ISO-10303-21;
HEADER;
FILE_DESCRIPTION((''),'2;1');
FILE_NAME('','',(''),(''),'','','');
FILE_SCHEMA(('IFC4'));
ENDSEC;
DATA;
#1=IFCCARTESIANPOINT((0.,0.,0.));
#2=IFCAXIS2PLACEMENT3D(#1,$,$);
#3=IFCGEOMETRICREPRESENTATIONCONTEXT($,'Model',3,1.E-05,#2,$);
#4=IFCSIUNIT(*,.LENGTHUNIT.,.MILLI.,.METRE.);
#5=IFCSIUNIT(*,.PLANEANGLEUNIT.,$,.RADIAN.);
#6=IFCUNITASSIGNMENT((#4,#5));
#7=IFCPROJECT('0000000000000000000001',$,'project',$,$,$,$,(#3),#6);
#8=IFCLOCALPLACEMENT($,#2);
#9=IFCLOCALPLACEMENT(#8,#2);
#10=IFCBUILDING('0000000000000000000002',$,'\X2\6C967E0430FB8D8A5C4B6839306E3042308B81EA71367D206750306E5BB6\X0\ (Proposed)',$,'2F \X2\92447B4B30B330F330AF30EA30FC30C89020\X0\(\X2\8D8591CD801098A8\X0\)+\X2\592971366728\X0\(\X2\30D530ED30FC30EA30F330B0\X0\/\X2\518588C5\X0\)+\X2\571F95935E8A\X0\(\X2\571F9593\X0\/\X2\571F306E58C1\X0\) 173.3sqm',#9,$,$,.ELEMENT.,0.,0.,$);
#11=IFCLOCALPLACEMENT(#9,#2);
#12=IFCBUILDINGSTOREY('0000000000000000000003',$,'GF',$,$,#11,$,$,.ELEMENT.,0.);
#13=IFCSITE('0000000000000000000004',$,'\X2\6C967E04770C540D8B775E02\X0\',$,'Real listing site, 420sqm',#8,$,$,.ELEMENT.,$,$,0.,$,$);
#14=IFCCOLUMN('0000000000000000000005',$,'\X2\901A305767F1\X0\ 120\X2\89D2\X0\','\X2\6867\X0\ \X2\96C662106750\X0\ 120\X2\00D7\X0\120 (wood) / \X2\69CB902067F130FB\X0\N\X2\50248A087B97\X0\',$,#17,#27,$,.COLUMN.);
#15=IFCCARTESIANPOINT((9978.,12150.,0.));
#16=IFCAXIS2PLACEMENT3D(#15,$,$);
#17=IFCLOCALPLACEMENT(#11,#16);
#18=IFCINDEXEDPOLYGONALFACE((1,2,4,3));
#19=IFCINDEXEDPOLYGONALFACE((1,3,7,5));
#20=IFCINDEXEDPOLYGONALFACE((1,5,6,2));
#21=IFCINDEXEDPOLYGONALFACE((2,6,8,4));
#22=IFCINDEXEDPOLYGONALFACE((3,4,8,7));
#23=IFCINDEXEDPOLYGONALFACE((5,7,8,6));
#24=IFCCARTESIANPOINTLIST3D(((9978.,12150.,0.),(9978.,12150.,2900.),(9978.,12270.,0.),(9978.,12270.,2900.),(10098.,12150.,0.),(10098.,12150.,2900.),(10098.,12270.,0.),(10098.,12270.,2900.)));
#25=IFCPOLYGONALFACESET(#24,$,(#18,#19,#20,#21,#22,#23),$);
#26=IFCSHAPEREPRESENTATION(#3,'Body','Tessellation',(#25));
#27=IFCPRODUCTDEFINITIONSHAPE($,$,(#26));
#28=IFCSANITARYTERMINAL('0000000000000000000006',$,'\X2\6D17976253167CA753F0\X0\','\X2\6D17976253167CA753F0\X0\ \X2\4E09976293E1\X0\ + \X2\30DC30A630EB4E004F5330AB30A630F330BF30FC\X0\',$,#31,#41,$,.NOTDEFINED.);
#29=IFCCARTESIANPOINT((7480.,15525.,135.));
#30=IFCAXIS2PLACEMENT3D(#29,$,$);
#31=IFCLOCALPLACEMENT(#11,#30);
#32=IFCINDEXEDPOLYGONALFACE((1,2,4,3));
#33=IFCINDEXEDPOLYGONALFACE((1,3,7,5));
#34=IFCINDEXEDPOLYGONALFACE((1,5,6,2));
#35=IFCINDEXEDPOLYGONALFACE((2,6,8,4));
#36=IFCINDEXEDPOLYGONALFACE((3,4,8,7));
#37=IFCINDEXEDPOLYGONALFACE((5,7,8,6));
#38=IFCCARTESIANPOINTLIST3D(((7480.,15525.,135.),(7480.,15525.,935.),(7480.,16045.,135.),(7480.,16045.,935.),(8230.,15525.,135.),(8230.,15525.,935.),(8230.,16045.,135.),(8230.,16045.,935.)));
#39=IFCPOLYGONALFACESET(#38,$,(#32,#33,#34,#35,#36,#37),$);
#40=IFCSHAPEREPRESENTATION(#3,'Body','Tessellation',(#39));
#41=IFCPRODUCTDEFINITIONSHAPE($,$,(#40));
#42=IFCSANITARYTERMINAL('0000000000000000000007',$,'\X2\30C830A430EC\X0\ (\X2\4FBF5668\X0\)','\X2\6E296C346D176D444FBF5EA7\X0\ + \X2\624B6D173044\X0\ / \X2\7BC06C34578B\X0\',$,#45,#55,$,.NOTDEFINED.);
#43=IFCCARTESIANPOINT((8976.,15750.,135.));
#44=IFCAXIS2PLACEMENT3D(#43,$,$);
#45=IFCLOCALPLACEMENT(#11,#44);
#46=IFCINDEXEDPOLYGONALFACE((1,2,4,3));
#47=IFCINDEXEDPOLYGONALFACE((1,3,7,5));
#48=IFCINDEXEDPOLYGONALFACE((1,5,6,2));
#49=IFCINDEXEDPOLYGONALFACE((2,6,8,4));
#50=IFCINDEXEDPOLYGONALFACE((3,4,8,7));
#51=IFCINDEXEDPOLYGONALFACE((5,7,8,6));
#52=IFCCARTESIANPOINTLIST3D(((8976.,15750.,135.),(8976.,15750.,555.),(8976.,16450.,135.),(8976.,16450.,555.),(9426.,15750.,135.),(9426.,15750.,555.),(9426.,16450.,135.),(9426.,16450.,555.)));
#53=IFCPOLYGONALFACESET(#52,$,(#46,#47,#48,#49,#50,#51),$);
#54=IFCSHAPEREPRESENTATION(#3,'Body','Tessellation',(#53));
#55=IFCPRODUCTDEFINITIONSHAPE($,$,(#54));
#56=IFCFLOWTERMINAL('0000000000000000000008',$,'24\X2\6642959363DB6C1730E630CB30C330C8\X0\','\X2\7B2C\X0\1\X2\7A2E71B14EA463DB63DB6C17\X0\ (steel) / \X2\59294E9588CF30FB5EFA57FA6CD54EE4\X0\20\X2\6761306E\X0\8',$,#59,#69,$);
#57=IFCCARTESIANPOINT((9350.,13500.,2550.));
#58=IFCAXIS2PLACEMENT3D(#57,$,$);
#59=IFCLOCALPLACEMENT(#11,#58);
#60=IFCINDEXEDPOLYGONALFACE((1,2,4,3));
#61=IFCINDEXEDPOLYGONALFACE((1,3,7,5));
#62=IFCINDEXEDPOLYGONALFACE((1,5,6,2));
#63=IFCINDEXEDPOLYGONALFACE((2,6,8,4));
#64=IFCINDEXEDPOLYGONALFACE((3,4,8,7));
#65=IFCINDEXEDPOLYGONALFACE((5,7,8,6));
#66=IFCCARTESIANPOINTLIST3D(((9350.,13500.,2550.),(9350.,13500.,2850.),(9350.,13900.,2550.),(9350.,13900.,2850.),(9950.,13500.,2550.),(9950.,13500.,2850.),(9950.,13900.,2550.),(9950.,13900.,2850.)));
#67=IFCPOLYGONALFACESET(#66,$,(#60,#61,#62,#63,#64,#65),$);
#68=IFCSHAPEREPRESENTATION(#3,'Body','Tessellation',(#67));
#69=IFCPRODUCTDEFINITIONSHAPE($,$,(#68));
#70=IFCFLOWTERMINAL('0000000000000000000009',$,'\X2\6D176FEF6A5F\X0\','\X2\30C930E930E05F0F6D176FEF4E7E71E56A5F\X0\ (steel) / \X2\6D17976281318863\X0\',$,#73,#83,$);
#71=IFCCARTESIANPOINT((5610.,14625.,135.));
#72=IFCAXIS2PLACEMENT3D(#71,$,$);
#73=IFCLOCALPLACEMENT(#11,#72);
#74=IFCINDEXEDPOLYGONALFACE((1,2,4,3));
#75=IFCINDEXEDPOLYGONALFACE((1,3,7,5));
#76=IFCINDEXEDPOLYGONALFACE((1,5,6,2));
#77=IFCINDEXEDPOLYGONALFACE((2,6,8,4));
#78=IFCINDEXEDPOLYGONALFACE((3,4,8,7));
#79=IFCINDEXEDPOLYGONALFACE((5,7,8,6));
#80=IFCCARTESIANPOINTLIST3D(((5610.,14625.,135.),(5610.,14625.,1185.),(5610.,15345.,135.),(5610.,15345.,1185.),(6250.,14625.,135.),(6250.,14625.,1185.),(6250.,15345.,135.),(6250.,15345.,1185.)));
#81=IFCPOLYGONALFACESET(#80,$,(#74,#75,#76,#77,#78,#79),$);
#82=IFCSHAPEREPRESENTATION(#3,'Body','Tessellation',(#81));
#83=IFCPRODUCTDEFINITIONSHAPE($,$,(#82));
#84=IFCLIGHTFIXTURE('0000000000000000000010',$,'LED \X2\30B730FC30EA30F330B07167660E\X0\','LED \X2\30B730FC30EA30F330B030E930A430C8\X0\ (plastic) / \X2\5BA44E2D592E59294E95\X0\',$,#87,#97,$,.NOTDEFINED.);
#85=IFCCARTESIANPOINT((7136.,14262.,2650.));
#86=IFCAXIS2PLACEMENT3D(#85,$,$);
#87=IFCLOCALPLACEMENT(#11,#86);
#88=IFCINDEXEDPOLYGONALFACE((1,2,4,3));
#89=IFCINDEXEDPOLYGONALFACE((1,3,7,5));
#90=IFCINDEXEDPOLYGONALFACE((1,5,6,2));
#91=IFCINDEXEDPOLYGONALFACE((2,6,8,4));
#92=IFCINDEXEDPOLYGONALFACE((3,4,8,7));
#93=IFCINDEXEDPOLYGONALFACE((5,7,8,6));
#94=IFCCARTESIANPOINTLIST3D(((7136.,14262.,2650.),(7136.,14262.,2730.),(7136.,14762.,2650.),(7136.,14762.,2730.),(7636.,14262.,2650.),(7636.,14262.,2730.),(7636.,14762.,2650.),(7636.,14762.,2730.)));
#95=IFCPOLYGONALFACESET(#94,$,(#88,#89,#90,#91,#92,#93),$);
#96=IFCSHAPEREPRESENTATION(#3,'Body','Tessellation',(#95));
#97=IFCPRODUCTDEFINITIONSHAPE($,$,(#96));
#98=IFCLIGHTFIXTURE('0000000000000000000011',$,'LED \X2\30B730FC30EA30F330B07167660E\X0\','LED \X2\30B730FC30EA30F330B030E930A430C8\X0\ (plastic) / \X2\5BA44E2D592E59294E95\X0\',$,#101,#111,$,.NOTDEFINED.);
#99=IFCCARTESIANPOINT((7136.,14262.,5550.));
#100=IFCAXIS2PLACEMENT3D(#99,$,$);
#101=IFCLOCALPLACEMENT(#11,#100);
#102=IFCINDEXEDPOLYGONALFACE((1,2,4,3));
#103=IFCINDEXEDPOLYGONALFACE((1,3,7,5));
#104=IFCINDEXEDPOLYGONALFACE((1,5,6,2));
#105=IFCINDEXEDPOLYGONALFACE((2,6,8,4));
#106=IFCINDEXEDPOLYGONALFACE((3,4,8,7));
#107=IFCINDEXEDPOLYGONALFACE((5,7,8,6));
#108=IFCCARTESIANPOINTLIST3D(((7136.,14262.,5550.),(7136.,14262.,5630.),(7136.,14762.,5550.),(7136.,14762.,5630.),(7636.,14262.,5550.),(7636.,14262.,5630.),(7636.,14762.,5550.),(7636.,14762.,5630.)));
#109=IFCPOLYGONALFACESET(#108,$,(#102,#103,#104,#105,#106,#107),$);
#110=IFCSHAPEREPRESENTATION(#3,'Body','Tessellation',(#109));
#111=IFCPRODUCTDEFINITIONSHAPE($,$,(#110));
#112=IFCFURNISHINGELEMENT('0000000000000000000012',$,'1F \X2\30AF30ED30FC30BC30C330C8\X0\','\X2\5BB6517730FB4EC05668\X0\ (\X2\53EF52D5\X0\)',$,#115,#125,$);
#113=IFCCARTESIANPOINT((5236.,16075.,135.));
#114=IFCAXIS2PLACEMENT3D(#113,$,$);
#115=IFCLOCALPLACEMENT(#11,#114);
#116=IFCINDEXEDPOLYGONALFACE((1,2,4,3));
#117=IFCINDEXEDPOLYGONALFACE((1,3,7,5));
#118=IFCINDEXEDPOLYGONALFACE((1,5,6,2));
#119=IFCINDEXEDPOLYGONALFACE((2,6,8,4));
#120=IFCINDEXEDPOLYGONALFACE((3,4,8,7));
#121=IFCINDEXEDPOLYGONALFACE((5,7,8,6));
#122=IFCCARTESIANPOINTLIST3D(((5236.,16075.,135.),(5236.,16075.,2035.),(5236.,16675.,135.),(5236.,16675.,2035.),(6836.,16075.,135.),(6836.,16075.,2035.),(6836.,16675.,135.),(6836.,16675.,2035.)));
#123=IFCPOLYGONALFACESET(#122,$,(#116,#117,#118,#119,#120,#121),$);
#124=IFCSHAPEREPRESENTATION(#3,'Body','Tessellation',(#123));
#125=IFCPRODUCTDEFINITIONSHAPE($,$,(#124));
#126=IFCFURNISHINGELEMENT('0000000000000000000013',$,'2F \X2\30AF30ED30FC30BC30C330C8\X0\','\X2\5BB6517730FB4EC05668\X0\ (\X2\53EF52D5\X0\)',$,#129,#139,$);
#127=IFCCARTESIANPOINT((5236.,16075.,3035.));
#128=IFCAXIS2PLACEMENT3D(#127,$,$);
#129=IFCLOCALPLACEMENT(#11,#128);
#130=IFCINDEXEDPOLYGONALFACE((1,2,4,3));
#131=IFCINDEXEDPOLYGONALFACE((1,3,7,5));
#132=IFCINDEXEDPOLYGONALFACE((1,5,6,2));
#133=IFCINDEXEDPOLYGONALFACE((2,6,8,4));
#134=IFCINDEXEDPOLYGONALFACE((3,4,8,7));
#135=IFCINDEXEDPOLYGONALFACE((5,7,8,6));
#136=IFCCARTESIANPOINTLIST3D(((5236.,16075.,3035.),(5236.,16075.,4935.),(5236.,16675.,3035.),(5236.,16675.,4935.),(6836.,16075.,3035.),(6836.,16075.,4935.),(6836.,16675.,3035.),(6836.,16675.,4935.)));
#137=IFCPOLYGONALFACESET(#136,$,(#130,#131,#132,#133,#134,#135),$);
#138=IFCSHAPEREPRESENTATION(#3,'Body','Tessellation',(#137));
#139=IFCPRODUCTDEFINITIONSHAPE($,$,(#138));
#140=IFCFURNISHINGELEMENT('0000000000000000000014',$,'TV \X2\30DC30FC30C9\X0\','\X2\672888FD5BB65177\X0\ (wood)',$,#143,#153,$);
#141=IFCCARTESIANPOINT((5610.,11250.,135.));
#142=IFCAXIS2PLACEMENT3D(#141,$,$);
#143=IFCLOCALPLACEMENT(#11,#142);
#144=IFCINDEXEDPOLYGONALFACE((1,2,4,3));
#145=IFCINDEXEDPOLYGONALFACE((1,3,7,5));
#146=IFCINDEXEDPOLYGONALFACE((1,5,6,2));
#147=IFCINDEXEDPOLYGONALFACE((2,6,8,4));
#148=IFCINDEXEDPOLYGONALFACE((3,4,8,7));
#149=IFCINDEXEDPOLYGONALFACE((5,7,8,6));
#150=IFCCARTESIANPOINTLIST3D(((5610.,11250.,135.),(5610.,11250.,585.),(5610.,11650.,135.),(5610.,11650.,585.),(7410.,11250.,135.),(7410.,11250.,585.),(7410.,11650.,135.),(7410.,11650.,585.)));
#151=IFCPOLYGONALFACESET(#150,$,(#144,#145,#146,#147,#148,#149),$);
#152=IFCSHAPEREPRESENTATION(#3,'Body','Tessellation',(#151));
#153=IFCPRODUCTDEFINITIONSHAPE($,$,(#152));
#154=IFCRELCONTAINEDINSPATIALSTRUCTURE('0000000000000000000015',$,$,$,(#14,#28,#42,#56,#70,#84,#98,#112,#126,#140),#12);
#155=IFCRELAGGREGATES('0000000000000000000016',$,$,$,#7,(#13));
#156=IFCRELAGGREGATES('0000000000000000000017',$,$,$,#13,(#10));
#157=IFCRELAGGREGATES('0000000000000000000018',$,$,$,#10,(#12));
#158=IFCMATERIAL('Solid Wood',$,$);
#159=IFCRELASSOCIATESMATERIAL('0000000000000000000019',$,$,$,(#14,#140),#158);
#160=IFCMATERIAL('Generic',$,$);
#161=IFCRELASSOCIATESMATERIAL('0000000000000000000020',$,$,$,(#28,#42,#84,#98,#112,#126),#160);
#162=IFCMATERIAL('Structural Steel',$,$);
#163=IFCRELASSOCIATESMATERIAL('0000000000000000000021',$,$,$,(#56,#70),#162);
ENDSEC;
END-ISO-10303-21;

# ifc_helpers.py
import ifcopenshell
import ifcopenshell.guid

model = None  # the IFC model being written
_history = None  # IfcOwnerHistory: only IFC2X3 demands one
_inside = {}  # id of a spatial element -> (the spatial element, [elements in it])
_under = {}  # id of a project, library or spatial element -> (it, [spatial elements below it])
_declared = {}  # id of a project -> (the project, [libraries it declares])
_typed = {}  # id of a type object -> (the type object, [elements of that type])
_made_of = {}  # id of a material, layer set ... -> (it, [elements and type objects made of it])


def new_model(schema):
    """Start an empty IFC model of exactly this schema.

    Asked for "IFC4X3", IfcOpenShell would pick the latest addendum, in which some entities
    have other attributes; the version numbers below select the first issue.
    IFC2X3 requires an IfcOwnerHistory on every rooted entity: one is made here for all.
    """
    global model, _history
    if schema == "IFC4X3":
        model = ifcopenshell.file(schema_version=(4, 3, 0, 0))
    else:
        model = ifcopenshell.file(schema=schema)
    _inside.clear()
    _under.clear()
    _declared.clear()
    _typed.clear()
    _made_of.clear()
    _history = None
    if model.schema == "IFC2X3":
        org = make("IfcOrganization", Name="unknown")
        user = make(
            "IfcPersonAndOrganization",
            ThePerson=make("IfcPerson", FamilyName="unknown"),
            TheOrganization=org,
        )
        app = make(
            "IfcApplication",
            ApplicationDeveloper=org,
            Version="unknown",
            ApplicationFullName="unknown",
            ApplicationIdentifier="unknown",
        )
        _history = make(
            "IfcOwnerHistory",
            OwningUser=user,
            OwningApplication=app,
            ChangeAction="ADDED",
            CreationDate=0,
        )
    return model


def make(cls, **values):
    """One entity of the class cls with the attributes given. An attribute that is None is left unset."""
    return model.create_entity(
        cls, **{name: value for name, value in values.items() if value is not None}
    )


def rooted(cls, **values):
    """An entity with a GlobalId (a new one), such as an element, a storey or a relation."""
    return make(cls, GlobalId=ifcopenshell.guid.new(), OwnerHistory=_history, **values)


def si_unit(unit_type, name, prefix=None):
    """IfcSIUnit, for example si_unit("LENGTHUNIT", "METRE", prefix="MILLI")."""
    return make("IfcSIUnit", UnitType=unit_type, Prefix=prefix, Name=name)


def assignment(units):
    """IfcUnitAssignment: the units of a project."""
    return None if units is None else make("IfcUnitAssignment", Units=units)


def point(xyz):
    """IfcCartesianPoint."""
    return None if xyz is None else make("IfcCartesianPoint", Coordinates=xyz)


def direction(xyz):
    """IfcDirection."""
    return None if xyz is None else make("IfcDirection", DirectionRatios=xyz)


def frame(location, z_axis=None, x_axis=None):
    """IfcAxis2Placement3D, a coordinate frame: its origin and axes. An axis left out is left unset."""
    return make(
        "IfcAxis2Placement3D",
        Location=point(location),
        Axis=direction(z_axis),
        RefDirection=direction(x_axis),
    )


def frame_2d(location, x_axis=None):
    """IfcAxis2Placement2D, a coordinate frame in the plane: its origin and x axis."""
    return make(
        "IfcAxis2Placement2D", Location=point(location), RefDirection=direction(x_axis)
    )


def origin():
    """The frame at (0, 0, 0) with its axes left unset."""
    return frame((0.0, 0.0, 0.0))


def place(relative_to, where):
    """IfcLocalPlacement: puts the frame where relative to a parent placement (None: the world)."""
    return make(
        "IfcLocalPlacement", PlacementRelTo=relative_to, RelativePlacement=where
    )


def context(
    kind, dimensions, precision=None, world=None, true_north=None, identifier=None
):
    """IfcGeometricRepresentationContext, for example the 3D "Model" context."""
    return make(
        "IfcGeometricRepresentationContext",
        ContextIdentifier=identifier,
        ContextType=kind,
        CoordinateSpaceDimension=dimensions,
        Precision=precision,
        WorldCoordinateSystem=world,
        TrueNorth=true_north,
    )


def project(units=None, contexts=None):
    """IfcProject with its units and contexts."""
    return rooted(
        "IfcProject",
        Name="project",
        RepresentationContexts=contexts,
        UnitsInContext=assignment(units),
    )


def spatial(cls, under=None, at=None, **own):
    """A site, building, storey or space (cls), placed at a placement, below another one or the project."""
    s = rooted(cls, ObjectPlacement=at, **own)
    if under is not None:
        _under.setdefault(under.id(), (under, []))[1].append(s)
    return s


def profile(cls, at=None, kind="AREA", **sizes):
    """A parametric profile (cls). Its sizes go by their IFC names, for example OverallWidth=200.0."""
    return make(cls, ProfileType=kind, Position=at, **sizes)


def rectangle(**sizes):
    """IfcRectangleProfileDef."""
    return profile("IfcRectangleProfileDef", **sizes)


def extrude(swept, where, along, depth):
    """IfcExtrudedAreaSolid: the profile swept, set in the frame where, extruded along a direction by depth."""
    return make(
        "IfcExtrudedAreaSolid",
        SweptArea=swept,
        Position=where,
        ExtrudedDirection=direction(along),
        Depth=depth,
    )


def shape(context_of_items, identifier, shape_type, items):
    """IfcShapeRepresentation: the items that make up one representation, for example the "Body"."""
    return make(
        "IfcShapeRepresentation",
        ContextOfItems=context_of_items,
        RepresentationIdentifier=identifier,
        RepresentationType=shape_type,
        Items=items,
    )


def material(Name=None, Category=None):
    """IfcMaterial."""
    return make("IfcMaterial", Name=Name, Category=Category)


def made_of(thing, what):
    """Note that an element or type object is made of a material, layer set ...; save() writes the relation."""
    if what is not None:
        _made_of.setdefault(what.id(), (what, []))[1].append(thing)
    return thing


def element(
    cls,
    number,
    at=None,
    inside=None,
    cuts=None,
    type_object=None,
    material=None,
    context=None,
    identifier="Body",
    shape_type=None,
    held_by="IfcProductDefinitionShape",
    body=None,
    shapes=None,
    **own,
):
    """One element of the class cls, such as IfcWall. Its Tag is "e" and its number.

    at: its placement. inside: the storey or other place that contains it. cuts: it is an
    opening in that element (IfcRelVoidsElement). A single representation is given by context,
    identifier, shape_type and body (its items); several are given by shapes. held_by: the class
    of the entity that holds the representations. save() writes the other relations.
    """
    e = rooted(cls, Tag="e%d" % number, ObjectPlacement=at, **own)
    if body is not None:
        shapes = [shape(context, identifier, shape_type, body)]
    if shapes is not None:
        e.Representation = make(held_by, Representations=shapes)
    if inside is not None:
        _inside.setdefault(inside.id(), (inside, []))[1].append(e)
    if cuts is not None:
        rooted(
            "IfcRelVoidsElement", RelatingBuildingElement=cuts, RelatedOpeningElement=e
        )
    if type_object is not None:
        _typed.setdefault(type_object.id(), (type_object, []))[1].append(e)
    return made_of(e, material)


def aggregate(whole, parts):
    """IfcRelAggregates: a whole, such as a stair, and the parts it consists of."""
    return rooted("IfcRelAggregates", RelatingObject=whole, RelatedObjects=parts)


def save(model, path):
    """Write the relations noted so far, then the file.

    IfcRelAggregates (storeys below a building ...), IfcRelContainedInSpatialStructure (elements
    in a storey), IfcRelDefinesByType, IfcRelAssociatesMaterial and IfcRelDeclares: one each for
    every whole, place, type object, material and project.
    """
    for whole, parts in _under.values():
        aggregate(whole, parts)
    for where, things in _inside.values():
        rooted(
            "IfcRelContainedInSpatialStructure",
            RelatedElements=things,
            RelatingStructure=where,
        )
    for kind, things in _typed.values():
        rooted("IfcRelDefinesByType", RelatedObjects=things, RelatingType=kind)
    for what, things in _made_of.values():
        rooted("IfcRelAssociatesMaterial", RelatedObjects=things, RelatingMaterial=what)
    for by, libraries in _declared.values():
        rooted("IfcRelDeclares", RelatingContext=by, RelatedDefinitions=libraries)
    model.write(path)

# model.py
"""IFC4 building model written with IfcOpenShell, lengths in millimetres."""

from ifc_helpers import new_model, si_unit, frame, frame_2d, origin, place, context, project, spatial, rectangle, extrude, material, element, save


model = new_model("IFC4")

# Units and contexts
model_context = context("Model", 3, precision=1e-05, world=origin())
ifc_project = project(units=[si_unit("LENGTHUNIT", "METRE", prefix="MILLI"), si_unit("PLANEANGLEUNIT", "RADIAN")], contexts=[model_context])

# Site, building, storey
site_placement = place(None, origin())
site = spatial("IfcSite", under=ifc_project, at=site_placement, Name="沖縄県名護市", ObjectType="Real listing site, 420sqm", CompositionType="ELEMENT", RefElevation=0.0)
building_placement = place(site_placement, origin())
building = spatial("IfcBuilding", under=site, at=building_placement, Name="沖縄・越屋根のある自然素材の家 (Proposed)", ObjectType="2F 鉄筋コンクリート造(超重耐風)+天然木(フローリング/内装)+土間床(土間/土の壁) 173.3sqm", CompositionType="ELEMENT", ElevationOfRefHeight=0.0, ElevationOfTerrain=0.0)
storey_placement = place(building_placement, origin())
storey = spatial("IfcBuildingStorey", under=building, at=storey_placement, Name="GF", CompositionType="ELEMENT", Elevation=0.0)

# Column
ifc_material_1 = material(Name="Solid Wood")
column_1_placement = place(storey_placement, frame((9978.0, 12150.0, 0.0)))
element("IfcColumn", 1, at=column_1_placement, inside=storey, material=ifc_material_1, Name="通し柱 120角", Description="桧 集成材 120×120 (wood) / 構造柱・N値計算", PredefinedType="COLUMN", context=model_context, shape_type="SweptSolid", body=[
    extrude(rectangle(XDim=120.0, YDim=120.0, at=frame_2d((60.0, 60.0))), frame((9978.0, 12150.0, 0.0)), (0.0, 0.0, 1.0), 2900.0),
])

# Sanitary terminals
ifc_material_2 = material(Name="Generic")
sanitary_terminal_1_placement = place(storey_placement, frame((7480.0, 15525.0, 135.0)))
element("IfcSanitaryTerminal", 2, at=sanitary_terminal_1_placement, inside=storey, material=ifc_material_2, Name="洗面化粧台", Description="洗面化粧台 三面鏡 + ボウル一体カウンター", PredefinedType="NOTDEFINED", context=model_context, shape_type="SweptSolid", body=[
    extrude(rectangle(XDim=750.0, YDim=520.0, at=frame_2d((375.0, 260.0))), frame((7480.0, 15525.0, 135.0)), (0.0, 0.0, 1.0), 800.0),
])
sanitary_terminal_2_placement = place(storey_placement, frame((8976.0, 15750.0, 135.0)))
element("IfcSanitaryTerminal", 3, at=sanitary_terminal_2_placement, inside=storey, material=ifc_material_2, Name="トイレ (便器)", Description="温水洗浄便座 + 手洗い / 節水型", PredefinedType="NOTDEFINED", context=model_context, shape_type="SweptSolid", body=[
    extrude(rectangle(XDim=450.0, YDim=700.0, at=frame_2d((225.0, 350.0))), frame((8976.0, 15750.0, 135.0)), (0.0, 0.0, 1.0), 420.0),
])

# Flow terminals
ifc_material_3 = material(Name="Structural Steel")
flow_terminal_1_placement = place(storey_placement, frame((9350.0, 13500.0, 2550.0)))
element("IfcFlowTerminal", 4, at=flow_terminal_1_placement, inside=storey, material=ifc_material_3, Name="24時間換気ユニット", Description="第1種熱交換換気 (steel) / 天井裏・建基法令20条の8", context=model_context, shape_type="SweptSolid", body=[
    extrude(rectangle(XDim=600.0, YDim=400.0, at=frame_2d((300.0, 200.0))), frame((9350.0, 13500.0, 2550.0)), (0.0, 0.0, 1.0), 300.0),
])
flow_terminal_2_placement = place(storey_placement, frame((5610.0, 14625.0, 135.0)))
element("IfcFlowTerminal", 5, at=flow_terminal_2_placement, inside=storey, material=ifc_material_3, Name="洗濯機", Description="ドラム式洗濯乾燥機 (steel) / 洗面脱衣", context=model_context, shape_type="SweptSolid", body=[
    extrude(rectangle(XDim=640.0, YDim=720.0, at=frame_2d((320.0, 360.0))), frame((5610.0, 14625.0, 135.0)), (0.0, 0.0, 1.0), 1050.0),
])

# Light fixtures
light_fixture_1_placement = place(storey_placement, frame((7136.0, 14262.0, 2650.0)))
element("IfcLightFixture", 6, at=light_fixture_1_placement, inside=storey, material=ifc_material_2, Name="LED シーリング照明", Description="LED シーリングライト (plastic) / 室中央天井", PredefinedType="NOTDEFINED", context=model_context, shape_type="SweptSolid", body=[
    extrude(rectangle(XDim=500.0, YDim=500.0, at=frame_2d((250.0, 250.0))), frame((7136.0, 14262.0, 2650.0)), (0.0, 0.0, 1.0), 80.0),
])
light_fixture_2_placement = place(storey_placement, frame((7136.0, 14262.0, 5550.0)))
element("IfcLightFixture", 7, at=light_fixture_2_placement, inside=storey, material=ifc_material_2, Name="LED シーリング照明", Description="LED シーリングライト (plastic) / 室中央天井", PredefinedType="NOTDEFINED", context=model_context, shape_type="SweptSolid", body=[
    extrude(rectangle(XDim=500.0, YDim=500.0, at=frame_2d((250.0, 250.0))), frame((7136.0, 14262.0, 5550.0)), (0.0, 0.0, 1.0), 80.0),
])

# Furnishing elements
furnishing_1_placement = place(storey_placement, frame((5236.0, 16075.0, 135.0)))
element("IfcFurnishingElement", 8, at=furnishing_1_placement, inside=storey, material=ifc_material_2, Name="1F クローゼット", Description="家具・什器 (可動)", context=model_context, shape_type="SweptSolid", body=[
    extrude(rectangle(XDim=1600.0, YDim=600.0, at=frame_2d((800.0, 300.0))), frame((5236.0, 16075.0, 135.0)), (0.0, 0.0, 1.0), 1900.0),
])
furnishing_2_placement = place(storey_placement, frame((5236.0, 16075.0, 3035.0)))
element("IfcFurnishingElement", 9, at=furnishing_2_placement, inside=storey, material=ifc_material_2, Name="2F クローゼット", Description="家具・什器 (可動)", context=model_context, shape_type="SweptSolid", body=[
    extrude(rectangle(XDim=1600.0, YDim=600.0, at=frame_2d((800.0, 300.0))), frame((5236.0, 16075.0, 3035.0)), (0.0, 0.0, 1.0), 1900.0),
])
furnishing_3_placement = place(storey_placement, frame((5610.0, 11250.0, 135.0)))
element("IfcFurnishingElement", 10, at=furnishing_3_placement, inside=storey, material=ifc_material_1, Name="TV ボード", Description="木製家具 (wood)", context=model_context, shape_type="SweptSolid", body=[
    extrude(rectangle(XDim=1800.0, YDim=400.0, at=frame_2d((900.0, 200.0))), frame((5610.0, 11250.0, 135.0)), (0.0, 0.0, 1.0), 450.0),
])

save(model, "model.ifc")
